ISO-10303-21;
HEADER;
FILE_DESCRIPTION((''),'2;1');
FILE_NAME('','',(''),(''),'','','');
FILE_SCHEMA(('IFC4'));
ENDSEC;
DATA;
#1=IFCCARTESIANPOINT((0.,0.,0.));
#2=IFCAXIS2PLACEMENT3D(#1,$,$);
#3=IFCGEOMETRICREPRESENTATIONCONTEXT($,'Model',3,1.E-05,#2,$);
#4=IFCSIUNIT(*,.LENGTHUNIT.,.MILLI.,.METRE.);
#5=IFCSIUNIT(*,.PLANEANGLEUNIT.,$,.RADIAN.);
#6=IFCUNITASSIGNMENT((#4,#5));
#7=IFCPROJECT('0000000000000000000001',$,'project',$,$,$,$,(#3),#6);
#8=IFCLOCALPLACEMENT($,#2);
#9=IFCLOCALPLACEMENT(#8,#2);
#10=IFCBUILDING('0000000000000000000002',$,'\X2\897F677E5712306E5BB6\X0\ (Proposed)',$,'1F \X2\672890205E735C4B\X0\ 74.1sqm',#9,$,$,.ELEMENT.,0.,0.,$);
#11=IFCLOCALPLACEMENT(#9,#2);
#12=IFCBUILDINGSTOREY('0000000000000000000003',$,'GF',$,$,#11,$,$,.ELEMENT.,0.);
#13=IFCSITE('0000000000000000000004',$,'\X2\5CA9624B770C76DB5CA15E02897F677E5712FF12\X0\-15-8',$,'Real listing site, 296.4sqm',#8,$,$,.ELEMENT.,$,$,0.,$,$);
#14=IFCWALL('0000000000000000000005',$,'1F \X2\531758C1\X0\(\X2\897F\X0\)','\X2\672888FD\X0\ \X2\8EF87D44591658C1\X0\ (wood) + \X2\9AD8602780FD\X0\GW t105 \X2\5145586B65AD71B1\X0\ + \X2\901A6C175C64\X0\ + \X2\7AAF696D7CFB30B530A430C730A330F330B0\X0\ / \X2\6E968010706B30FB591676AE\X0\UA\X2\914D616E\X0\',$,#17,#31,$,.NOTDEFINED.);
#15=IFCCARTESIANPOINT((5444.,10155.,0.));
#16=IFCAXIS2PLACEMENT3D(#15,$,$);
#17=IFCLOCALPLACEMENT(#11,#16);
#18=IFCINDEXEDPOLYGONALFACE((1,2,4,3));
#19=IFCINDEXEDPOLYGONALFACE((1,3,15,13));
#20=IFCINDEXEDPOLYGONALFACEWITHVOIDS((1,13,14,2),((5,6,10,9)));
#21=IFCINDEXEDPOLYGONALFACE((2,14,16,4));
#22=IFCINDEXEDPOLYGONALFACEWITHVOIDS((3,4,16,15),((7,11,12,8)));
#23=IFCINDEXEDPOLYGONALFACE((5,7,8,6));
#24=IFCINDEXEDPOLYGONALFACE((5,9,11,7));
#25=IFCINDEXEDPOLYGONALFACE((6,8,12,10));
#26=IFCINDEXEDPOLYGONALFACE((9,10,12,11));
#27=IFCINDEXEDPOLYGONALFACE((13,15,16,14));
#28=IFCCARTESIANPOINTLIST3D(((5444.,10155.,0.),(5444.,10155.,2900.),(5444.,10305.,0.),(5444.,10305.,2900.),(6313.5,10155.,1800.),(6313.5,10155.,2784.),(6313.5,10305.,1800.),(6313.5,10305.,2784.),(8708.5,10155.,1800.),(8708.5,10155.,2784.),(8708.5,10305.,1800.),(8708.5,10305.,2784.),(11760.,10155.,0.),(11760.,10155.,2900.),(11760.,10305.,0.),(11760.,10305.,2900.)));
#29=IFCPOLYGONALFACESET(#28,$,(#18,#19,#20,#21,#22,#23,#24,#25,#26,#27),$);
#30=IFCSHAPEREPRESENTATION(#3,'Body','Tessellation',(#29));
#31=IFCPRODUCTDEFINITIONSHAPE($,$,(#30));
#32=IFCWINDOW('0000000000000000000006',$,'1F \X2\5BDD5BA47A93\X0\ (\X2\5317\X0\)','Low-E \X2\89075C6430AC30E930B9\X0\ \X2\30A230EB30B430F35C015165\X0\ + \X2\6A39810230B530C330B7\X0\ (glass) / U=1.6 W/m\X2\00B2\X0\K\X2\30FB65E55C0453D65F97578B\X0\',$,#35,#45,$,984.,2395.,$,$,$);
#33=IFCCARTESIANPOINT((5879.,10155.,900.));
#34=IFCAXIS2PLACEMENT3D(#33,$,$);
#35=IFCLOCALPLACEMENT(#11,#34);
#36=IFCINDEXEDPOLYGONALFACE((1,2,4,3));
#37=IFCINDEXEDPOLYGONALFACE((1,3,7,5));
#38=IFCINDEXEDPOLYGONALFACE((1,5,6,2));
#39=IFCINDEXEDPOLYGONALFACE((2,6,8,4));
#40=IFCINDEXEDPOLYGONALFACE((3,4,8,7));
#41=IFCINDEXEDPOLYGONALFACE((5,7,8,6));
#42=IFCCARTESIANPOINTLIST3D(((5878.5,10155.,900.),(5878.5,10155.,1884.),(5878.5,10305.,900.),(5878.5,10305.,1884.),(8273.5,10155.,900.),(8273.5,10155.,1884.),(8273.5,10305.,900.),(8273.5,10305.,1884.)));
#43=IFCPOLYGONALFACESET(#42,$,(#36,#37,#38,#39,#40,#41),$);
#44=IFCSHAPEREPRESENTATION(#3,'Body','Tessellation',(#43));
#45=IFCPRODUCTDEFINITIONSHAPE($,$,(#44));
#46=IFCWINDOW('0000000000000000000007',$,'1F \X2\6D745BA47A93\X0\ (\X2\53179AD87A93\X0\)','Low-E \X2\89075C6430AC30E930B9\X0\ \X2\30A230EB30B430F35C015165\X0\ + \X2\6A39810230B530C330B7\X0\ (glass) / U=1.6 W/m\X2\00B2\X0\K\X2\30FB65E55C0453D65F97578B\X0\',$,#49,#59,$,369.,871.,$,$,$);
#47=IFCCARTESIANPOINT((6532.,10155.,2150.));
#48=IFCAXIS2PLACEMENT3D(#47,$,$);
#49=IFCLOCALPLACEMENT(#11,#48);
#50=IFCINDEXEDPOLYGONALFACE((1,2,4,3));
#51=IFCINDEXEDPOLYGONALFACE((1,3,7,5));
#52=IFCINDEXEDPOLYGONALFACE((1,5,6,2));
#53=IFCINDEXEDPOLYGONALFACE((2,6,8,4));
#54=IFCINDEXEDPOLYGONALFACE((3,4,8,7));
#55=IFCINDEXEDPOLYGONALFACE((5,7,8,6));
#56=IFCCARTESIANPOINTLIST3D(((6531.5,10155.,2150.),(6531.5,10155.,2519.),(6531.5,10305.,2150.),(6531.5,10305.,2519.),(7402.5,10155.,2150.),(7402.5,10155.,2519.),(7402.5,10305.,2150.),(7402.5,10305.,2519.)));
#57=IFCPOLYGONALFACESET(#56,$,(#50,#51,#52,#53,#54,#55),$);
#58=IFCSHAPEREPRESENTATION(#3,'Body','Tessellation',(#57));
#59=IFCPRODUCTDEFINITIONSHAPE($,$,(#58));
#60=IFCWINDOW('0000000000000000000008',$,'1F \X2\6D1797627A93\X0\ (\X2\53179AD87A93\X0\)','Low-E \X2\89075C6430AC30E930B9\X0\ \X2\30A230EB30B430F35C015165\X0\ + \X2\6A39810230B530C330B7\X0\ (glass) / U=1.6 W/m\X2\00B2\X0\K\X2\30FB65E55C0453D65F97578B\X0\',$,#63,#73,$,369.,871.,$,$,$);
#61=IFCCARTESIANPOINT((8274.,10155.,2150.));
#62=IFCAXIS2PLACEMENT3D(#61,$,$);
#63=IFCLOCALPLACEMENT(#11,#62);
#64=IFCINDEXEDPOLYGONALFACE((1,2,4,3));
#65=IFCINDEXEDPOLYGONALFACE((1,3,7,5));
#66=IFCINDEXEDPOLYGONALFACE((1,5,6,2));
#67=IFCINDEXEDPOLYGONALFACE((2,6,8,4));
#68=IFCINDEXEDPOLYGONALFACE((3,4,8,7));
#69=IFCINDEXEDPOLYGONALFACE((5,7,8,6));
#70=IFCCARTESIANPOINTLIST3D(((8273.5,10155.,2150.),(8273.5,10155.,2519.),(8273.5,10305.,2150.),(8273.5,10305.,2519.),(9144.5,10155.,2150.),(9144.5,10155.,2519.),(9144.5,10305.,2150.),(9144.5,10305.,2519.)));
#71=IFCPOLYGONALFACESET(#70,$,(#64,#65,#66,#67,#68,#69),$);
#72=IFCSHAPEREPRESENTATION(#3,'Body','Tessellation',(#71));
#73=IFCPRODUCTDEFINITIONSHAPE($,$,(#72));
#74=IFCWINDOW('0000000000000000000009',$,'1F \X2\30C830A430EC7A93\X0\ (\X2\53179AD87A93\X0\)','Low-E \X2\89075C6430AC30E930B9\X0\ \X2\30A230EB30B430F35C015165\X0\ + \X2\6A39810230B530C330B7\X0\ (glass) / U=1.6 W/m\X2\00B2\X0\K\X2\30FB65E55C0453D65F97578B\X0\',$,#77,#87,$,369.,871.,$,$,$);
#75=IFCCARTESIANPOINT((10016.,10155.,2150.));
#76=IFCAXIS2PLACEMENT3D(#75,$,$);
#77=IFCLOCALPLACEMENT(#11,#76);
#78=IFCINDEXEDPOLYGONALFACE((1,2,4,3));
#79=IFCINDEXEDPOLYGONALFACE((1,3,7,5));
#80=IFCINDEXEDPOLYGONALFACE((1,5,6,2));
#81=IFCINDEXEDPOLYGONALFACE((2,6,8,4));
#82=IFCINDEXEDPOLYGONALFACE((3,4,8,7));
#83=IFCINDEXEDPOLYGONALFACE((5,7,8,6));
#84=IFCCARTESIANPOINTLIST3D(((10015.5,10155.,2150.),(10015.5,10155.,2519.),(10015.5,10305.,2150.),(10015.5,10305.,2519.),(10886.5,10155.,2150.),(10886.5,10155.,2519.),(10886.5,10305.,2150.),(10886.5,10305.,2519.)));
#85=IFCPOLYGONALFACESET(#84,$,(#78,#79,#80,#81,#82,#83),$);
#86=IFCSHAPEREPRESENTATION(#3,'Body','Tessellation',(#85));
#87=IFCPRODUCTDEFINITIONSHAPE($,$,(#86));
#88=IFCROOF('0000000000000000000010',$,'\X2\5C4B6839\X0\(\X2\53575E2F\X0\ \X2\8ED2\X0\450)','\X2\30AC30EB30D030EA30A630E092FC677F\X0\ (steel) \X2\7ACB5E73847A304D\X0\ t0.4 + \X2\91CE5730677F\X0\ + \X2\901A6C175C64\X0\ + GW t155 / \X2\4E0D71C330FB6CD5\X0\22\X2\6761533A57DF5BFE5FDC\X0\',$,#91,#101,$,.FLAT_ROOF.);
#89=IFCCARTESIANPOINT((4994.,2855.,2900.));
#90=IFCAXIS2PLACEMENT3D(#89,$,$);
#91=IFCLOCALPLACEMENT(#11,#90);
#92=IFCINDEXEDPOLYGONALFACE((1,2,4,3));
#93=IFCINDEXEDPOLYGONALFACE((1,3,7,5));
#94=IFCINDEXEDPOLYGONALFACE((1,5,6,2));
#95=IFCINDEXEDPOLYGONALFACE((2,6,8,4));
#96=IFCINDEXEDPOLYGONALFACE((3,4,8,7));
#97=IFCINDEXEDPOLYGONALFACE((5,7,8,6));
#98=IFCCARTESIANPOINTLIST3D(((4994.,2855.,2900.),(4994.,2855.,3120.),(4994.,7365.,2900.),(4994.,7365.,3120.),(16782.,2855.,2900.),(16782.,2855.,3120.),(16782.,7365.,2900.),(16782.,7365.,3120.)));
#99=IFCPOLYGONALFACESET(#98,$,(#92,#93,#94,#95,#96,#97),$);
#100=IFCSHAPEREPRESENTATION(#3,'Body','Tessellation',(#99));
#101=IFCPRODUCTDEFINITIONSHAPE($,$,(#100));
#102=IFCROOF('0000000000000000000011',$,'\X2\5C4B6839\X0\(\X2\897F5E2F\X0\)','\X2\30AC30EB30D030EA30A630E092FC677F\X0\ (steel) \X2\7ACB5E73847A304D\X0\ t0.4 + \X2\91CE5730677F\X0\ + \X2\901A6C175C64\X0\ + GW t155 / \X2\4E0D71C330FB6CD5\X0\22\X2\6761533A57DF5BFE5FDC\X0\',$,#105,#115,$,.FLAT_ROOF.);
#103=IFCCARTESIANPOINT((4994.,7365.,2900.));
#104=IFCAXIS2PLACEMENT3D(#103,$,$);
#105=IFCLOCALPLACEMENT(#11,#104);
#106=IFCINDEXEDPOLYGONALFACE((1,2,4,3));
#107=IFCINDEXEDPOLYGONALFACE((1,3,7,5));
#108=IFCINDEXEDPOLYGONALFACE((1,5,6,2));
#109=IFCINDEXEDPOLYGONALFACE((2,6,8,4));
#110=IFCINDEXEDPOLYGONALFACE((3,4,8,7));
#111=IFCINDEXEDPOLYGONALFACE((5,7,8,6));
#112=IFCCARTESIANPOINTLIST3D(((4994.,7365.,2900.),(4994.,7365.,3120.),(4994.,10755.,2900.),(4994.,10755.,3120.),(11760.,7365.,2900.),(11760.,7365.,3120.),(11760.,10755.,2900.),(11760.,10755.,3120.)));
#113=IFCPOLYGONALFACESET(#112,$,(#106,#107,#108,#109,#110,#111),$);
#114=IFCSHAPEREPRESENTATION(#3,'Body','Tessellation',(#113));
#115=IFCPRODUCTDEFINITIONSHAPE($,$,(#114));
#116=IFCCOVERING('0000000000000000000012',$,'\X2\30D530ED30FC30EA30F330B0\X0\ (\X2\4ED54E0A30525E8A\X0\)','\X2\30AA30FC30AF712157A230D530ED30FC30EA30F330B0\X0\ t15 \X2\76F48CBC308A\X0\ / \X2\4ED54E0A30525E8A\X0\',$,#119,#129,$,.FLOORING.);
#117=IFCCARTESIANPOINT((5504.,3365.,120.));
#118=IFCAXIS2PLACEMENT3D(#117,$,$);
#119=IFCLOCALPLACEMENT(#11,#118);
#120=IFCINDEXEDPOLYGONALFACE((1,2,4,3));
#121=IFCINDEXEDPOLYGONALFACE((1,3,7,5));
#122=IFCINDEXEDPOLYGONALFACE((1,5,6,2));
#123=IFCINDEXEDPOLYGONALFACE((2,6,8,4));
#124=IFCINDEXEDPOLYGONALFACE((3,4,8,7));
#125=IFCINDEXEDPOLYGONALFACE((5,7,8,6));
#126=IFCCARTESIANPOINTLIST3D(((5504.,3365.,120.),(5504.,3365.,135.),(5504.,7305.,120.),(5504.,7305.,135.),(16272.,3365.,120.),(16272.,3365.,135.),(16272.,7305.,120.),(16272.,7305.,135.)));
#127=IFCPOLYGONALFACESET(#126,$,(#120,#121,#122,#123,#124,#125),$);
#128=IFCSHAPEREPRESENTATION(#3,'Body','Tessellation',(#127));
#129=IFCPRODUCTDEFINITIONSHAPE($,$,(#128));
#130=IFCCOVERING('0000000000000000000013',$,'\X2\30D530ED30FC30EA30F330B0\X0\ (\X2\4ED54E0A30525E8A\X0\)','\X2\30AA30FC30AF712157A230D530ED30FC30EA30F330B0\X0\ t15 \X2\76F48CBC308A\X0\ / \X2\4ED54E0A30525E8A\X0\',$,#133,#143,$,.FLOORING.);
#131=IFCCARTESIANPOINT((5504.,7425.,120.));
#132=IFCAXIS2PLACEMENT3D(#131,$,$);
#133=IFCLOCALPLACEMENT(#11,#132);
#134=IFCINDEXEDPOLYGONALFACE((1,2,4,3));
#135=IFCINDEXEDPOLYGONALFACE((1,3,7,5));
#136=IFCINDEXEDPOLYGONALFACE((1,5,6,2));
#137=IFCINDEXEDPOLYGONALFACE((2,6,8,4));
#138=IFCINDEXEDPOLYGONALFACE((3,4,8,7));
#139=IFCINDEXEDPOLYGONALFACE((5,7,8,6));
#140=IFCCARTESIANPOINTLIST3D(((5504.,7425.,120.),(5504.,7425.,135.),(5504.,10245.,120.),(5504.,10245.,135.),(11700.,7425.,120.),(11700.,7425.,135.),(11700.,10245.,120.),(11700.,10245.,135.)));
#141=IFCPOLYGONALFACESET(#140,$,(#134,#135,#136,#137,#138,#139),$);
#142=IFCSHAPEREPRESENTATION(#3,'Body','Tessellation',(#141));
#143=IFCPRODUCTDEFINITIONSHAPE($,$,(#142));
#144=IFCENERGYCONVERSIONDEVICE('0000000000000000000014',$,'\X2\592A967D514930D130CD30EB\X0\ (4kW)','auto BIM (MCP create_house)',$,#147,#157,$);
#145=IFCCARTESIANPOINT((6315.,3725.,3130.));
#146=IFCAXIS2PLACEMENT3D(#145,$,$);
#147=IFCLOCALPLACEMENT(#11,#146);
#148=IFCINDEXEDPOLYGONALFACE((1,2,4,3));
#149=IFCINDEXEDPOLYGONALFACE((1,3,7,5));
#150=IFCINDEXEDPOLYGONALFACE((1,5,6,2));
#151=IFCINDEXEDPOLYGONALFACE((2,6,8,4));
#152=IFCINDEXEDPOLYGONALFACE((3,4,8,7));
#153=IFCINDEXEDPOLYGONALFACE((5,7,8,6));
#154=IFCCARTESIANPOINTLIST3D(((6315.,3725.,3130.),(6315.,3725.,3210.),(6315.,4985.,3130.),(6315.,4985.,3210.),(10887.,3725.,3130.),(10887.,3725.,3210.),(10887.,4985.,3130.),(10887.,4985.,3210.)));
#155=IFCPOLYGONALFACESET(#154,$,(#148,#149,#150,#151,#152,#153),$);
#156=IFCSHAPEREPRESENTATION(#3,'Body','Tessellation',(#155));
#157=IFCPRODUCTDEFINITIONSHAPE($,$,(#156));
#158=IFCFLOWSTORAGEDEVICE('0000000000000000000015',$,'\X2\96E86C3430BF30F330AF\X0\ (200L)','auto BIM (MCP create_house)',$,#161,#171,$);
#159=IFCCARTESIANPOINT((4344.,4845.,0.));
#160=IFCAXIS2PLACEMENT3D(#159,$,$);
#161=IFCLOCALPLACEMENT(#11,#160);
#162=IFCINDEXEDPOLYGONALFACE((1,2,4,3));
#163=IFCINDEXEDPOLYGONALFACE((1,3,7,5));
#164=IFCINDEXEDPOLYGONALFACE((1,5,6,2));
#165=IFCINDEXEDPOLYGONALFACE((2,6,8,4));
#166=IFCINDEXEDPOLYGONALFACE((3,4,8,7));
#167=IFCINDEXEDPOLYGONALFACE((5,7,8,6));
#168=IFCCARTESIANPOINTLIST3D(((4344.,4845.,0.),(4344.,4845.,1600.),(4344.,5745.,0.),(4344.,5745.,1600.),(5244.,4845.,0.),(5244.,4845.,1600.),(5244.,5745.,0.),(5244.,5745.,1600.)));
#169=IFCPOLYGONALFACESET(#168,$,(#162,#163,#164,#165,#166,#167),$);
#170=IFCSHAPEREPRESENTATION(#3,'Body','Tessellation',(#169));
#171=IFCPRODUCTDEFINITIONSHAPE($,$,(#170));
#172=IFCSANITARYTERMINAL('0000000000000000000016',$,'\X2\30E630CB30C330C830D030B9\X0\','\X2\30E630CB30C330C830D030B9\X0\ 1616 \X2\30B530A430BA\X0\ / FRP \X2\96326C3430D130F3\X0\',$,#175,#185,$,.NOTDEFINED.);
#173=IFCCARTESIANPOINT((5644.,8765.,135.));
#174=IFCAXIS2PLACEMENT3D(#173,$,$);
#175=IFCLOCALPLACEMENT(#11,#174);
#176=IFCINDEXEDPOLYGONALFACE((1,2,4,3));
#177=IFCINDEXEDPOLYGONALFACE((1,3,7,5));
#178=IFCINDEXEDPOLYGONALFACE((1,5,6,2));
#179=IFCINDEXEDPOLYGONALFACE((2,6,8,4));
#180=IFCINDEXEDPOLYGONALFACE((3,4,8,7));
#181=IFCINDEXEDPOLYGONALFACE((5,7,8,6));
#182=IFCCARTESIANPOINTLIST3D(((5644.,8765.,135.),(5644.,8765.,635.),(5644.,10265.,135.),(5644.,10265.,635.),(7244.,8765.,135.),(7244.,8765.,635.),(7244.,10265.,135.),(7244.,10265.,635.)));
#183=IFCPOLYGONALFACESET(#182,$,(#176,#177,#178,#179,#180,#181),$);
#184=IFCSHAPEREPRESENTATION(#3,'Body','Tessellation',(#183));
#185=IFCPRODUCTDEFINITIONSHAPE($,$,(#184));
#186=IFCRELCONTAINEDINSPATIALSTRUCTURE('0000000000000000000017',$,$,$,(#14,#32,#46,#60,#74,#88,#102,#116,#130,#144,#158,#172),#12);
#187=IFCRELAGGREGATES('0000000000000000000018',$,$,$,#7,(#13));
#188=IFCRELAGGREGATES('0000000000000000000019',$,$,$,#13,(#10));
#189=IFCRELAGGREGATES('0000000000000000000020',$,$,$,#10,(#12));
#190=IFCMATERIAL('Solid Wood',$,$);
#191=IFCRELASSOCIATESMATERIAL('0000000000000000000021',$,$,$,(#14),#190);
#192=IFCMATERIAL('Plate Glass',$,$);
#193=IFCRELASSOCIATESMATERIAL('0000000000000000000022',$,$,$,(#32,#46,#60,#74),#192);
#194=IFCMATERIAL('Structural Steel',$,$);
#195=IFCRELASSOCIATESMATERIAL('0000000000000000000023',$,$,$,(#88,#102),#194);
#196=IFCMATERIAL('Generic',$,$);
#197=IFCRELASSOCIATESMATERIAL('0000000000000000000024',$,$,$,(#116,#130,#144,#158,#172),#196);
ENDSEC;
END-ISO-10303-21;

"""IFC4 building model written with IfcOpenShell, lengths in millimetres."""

from ifc_helpers import new_model, si_unit, frame, frame_2d, origin, place, context, project, spatial, rectangle, extrude, material, element, fill, save


model = new_model("IFC4")

# Units and contexts
model_context = context("Model", 3, precision=1e-05, world=origin())
ifc_project = project(units=[si_unit("LENGTHUNIT", "METRE", prefix="MILLI"), si_unit("PLANEANGLEUNIT", "RADIAN")], contexts=[model_context])

# Site, building, storey
site_placement = place(None, origin())
site = spatial("IfcSite", under=ifc_project, at=site_placement, Name="岩手県盛岡市西松園２-15-8", ObjectType="Real listing site, 296.4sqm", CompositionType="ELEMENT", RefElevation=0.0)
building_placement = place(site_placement, origin())
building = spatial("IfcBuilding", under=site, at=building_placement, Name="西松園の家 (Proposed)", ObjectType="1F 木造平屋 74.1sqm", CompositionType="ELEMENT", ElevationOfRefHeight=0.0, ElevationOfTerrain=0.0)
storey_placement = place(building_placement, origin())
storey = spatial("IfcBuildingStorey", under=building, at=storey_placement, Name="GF", CompositionType="ELEMENT", Elevation=0.0)

# Shared definitions
ifc_material_1 = material(Name="Solid Wood")

# Shared definitions
ifc_material_2 = material(Name="Plate Glass")

# Wall, openings, windows
wall_1_placement = place(storey_placement, frame((5444.0, 10155.0, 0.0)))
wall_1 = element("IfcWall", 1, at=wall_1_placement, inside=storey, material=ifc_material_1, Name="1F 北壁(西)", Description="木製 軸組外壁 (wood) + 高性能GW t105 充填断熱 + 通気層 + 窯業系サイディング / 準耐火・外皮UA配慮", PredefinedType="NOTDEFINED", context=model_context, shape_type="SweptSolid", body=[
    extrude(rectangle(XDim=6316.0, YDim=150.0, at=frame_2d((3158.0, 75.0))), frame((5444.0, 10155.0, 0.0)), (0.0, 0.0, 1.0), 2900.0),
])
opening_1_placement = place(storey_placement, frame((5879.0, 10155.0, 900.0)))
opening_1 = element("IfcOpeningElement", 2, at=opening_1_placement, cuts=wall_1, PredefinedType="NOTDEFINED", context=model_context, shape_type="SweptSolid", body=[
    extrude(rectangle(XDim=2395.0, YDim=150.0, at=frame_2d((1197.0, 75.0))), frame((5879.0, 10155.0, 900.0)), (0.0, 0.0, 1.0), 984.0),
])
opening_2_placement = place(storey_placement, frame((6532.0, 10155.0, 2150.0)))
opening_2 = element("IfcOpeningElement", 3, at=opening_2_placement, cuts=wall_1, PredefinedType="NOTDEFINED", context=model_context, shape_type="SweptSolid", body=[
    extrude(rectangle(XDim=871.0, YDim=150.0, at=frame_2d((435.0, 75.0))), frame((6532.0, 10155.0, 2150.0)), (0.0, 0.0, 1.0), 369.0),
])
opening_3_placement = place(storey_placement, frame((8274.0, 10155.0, 2150.0)))
opening_3 = element("IfcOpeningElement", 4, at=opening_3_placement, cuts=wall_1, PredefinedType="NOTDEFINED", context=model_context, shape_type="SweptSolid", body=[
    extrude(rectangle(XDim=871.0, YDim=150.0, at=frame_2d((435.0, 75.0))), frame((8274.0, 10155.0, 2150.0)), (0.0, 0.0, 1.0), 369.0),
])
opening_4_placement = place(storey_placement, frame((10016.0, 10155.0, 2150.0)))
opening_4 = element("IfcOpeningElement", 5, at=opening_4_placement, cuts=wall_1, PredefinedType="NOTDEFINED", context=model_context, shape_type="SweptSolid", body=[
    extrude(rectangle(XDim=871.0, YDim=150.0, at=frame_2d((435.0, 75.0))), frame((10016.0, 10155.0, 2150.0)), (0.0, 0.0, 1.0), 369.0),
])
window_1_placement = place(storey_placement, frame((5879.0, 10155.0, 900.0)))
window_1 = element("IfcWindow", 6, at=window_1_placement, inside=storey, material=ifc_material_2, Name="1F 寝室窓 (北)", Description="Low-E 複層ガラス アルゴン封入 + 樹脂サッシ (glass) / U=1.6 W/m²K・日射取得型", OverallHeight=984.0, OverallWidth=2395.0, context=model_context, shape_type="SweptSolid", body=[
    extrude(rectangle(XDim=2395.0, YDim=150.0, at=frame_2d((1197.0, 75.0))), frame((5879.0, 10155.0, 900.0)), (0.0, 0.0, 1.0), 984.0),
])
fill(opening_1, window_1)
window_2_placement = place(storey_placement, frame((6532.0, 10155.0, 2150.0)))
window_2 = element("IfcWindow", 7, at=window_2_placement, inside=storey, material=ifc_material_2, Name="1F 浴室窓 (北高窓)", Description="Low-E 複層ガラス アルゴン封入 + 樹脂サッシ (glass) / U=1.6 W/m²K・日射取得型", OverallHeight=369.0, OverallWidth=871.0, context=model_context, shape_type="SweptSolid", body=[
    extrude(rectangle(XDim=871.0, YDim=150.0, at=frame_2d((435.0, 75.0))), frame((6532.0, 10155.0, 2150.0)), (0.0, 0.0, 1.0), 369.0),
])
fill(opening_2, window_2)
window_3_placement = place(storey_placement, frame((8274.0, 10155.0, 2150.0)))
window_3 = element("IfcWindow", 8, at=window_3_placement, inside=storey, material=ifc_material_2, Name="1F 洗面窓 (北高窓)", Description="Low-E 複層ガラス アルゴン封入 + 樹脂サッシ (glass) / U=1.6 W/m²K・日射取得型", OverallHeight=369.0, OverallWidth=871.0, context=model_context, shape_type="SweptSolid", body=[
    extrude(rectangle(XDim=871.0, YDim=150.0, at=frame_2d((435.0, 75.0))), frame((8274.0, 10155.0, 2150.0)), (0.0, 0.0, 1.0), 369.0),
])
fill(opening_3, window_3)
window_4_placement = place(storey_placement, frame((10016.0, 10155.0, 2150.0)))
window_4 = element("IfcWindow", 9, at=window_4_placement, inside=storey, material=ifc_material_2, Name="1F トイレ窓 (北高窓)", Description="Low-E 複層ガラス アルゴン封入 + 樹脂サッシ (glass) / U=1.6 W/m²K・日射取得型", OverallHeight=369.0, OverallWidth=871.0, context=model_context, shape_type="SweptSolid", body=[
    extrude(rectangle(XDim=871.0, YDim=150.0, at=frame_2d((435.0, 75.0))), frame((10016.0, 10155.0, 2150.0)), (0.0, 0.0, 1.0), 369.0),
])
fill(opening_4, window_4)

# Roofs
ifc_material_3 = material(Name="Structural Steel")
roof_1_placement = place(storey_placement, frame((4994.0, 2855.0, 2900.0)))
element("IfcRoof", 10, at=roof_1_placement, inside=storey, material=ifc_material_3, Name="屋根(南帯 軒450)", Description="ガルバリウム鋼板 (steel) 立平葺き t0.4 + 野地板 + 通気層 + GW t155 / 不燃・法22条区域対応", PredefinedType="FLAT_ROOF", context=model_context, shape_type="SweptSolid", body=[
    extrude(rectangle(XDim=11788.0, YDim=4510.0, at=frame_2d((5894.0, 2255.0))), frame((4994.0, 2855.0, 2900.0)), (0.0, 0.0, 1.0), 220.0),
])
roof_2_placement = place(storey_placement, frame((4994.0, 7365.0, 2900.0)))
element("IfcRoof", 11, at=roof_2_placement, inside=storey, material=ifc_material_3, Name="屋根(西帯)", Description="ガルバリウム鋼板 (steel) 立平葺き t0.4 + 野地板 + 通気層 + GW t155 / 不燃・法22条区域対応", PredefinedType="FLAT_ROOF", context=model_context, shape_type="SweptSolid", body=[
    extrude(rectangle(XDim=6766.0, YDim=3390.0, at=frame_2d((3383.0, 1695.0))), frame((4994.0, 7365.0, 2900.0)), (0.0, 0.0, 1.0), 220.0),
])

# Coverings
ifc_material_4 = material(Name="Generic")
covering_1_placement = place(storey_placement, frame((5504.0, 3365.0, 120.0)))
element("IfcCovering", 12, at=covering_1_placement, inside=storey, material=ifc_material_4, Name="フローリング (仕上げ床)", Description="オーク無垢フローリング t15 直貼り / 仕上げ床", PredefinedType="FLOORING", context=model_context, shape_type="SweptSolid", body=[
    extrude(rectangle(XDim=10768.0, YDim=3940.0, at=frame_2d((5384.0, 1970.0))), frame((5504.0, 3365.0, 120.0)), (0.0, 0.0, 1.0), 15.0),
])
covering_2_placement = place(storey_placement, frame((5504.0, 7425.0, 120.0)))
element("IfcCovering", 13, at=covering_2_placement, inside=storey, material=ifc_material_4, Name="フローリング (仕上げ床)", Description="オーク無垢フローリング t15 直貼り / 仕上げ床", PredefinedType="FLOORING", context=model_context, shape_type="SweptSolid", body=[
    extrude(rectangle(XDim=6196.0, YDim=2820.0, at=frame_2d((3098.0, 1410.0))), frame((5504.0, 7425.0, 120.0)), (0.0, 0.0, 1.0), 15.0),
])

# Energy conversion device
energy_conversion_device_placement = place(storey_placement, frame((6315.0, 3725.0, 3130.0)))
element("IfcEnergyConversionDevice", 14, at=energy_conversion_device_placement, inside=storey, material=ifc_material_4, Name="太陽光パネル (4kW)", Description="auto BIM (MCP create_house)", context=model_context, shape_type="SweptSolid", body=[
    extrude(rectangle(XDim=4572.0, YDim=1260.0, at=frame_2d((2286.0, 630.0))), frame((6315.0, 3725.0, 3130.0)), (0.0, 0.0, 1.0), 80.0),
])

# Flow storage device
flow_storage_device_placement = place(storey_placement, frame((4344.0, 4845.0, 0.0)))
element("IfcFlowStorageDevice", 15, at=flow_storage_device_placement, inside=storey, material=ifc_material_4, Name="雨水タンク (200L)", Description="auto BIM (MCP create_house)", context=model_context, shape_type="SweptSolid", body=[
    extrude(rectangle(XDim=900.0, YDim=900.0, at=frame_2d((450.0, 450.0))), frame((4344.0, 4845.0, 0.0)), (0.0, 0.0, 1.0), 1600.0),
])

# Sanitary terminal
sanitary_terminal_placement = place(storey_placement, frame((5644.0, 8765.0, 135.0)))
element("IfcSanitaryTerminal", 16, at=sanitary_terminal_placement, inside=storey, material=ifc_material_4, Name="ユニットバス", Description="ユニットバス 1616 サイズ / FRP 防水パン", PredefinedType="NOTDEFINED", context=model_context, shape_type="SweptSolid", body=[
    extrude(rectangle(XDim=1600.0, YDim=1500.0, at=frame_2d((800.0, 750.0))), frame((5644.0, 8765.0, 135.0)), (0.0, 0.0, 1.0), 500.0),
])

save(model, "model.ifc")
